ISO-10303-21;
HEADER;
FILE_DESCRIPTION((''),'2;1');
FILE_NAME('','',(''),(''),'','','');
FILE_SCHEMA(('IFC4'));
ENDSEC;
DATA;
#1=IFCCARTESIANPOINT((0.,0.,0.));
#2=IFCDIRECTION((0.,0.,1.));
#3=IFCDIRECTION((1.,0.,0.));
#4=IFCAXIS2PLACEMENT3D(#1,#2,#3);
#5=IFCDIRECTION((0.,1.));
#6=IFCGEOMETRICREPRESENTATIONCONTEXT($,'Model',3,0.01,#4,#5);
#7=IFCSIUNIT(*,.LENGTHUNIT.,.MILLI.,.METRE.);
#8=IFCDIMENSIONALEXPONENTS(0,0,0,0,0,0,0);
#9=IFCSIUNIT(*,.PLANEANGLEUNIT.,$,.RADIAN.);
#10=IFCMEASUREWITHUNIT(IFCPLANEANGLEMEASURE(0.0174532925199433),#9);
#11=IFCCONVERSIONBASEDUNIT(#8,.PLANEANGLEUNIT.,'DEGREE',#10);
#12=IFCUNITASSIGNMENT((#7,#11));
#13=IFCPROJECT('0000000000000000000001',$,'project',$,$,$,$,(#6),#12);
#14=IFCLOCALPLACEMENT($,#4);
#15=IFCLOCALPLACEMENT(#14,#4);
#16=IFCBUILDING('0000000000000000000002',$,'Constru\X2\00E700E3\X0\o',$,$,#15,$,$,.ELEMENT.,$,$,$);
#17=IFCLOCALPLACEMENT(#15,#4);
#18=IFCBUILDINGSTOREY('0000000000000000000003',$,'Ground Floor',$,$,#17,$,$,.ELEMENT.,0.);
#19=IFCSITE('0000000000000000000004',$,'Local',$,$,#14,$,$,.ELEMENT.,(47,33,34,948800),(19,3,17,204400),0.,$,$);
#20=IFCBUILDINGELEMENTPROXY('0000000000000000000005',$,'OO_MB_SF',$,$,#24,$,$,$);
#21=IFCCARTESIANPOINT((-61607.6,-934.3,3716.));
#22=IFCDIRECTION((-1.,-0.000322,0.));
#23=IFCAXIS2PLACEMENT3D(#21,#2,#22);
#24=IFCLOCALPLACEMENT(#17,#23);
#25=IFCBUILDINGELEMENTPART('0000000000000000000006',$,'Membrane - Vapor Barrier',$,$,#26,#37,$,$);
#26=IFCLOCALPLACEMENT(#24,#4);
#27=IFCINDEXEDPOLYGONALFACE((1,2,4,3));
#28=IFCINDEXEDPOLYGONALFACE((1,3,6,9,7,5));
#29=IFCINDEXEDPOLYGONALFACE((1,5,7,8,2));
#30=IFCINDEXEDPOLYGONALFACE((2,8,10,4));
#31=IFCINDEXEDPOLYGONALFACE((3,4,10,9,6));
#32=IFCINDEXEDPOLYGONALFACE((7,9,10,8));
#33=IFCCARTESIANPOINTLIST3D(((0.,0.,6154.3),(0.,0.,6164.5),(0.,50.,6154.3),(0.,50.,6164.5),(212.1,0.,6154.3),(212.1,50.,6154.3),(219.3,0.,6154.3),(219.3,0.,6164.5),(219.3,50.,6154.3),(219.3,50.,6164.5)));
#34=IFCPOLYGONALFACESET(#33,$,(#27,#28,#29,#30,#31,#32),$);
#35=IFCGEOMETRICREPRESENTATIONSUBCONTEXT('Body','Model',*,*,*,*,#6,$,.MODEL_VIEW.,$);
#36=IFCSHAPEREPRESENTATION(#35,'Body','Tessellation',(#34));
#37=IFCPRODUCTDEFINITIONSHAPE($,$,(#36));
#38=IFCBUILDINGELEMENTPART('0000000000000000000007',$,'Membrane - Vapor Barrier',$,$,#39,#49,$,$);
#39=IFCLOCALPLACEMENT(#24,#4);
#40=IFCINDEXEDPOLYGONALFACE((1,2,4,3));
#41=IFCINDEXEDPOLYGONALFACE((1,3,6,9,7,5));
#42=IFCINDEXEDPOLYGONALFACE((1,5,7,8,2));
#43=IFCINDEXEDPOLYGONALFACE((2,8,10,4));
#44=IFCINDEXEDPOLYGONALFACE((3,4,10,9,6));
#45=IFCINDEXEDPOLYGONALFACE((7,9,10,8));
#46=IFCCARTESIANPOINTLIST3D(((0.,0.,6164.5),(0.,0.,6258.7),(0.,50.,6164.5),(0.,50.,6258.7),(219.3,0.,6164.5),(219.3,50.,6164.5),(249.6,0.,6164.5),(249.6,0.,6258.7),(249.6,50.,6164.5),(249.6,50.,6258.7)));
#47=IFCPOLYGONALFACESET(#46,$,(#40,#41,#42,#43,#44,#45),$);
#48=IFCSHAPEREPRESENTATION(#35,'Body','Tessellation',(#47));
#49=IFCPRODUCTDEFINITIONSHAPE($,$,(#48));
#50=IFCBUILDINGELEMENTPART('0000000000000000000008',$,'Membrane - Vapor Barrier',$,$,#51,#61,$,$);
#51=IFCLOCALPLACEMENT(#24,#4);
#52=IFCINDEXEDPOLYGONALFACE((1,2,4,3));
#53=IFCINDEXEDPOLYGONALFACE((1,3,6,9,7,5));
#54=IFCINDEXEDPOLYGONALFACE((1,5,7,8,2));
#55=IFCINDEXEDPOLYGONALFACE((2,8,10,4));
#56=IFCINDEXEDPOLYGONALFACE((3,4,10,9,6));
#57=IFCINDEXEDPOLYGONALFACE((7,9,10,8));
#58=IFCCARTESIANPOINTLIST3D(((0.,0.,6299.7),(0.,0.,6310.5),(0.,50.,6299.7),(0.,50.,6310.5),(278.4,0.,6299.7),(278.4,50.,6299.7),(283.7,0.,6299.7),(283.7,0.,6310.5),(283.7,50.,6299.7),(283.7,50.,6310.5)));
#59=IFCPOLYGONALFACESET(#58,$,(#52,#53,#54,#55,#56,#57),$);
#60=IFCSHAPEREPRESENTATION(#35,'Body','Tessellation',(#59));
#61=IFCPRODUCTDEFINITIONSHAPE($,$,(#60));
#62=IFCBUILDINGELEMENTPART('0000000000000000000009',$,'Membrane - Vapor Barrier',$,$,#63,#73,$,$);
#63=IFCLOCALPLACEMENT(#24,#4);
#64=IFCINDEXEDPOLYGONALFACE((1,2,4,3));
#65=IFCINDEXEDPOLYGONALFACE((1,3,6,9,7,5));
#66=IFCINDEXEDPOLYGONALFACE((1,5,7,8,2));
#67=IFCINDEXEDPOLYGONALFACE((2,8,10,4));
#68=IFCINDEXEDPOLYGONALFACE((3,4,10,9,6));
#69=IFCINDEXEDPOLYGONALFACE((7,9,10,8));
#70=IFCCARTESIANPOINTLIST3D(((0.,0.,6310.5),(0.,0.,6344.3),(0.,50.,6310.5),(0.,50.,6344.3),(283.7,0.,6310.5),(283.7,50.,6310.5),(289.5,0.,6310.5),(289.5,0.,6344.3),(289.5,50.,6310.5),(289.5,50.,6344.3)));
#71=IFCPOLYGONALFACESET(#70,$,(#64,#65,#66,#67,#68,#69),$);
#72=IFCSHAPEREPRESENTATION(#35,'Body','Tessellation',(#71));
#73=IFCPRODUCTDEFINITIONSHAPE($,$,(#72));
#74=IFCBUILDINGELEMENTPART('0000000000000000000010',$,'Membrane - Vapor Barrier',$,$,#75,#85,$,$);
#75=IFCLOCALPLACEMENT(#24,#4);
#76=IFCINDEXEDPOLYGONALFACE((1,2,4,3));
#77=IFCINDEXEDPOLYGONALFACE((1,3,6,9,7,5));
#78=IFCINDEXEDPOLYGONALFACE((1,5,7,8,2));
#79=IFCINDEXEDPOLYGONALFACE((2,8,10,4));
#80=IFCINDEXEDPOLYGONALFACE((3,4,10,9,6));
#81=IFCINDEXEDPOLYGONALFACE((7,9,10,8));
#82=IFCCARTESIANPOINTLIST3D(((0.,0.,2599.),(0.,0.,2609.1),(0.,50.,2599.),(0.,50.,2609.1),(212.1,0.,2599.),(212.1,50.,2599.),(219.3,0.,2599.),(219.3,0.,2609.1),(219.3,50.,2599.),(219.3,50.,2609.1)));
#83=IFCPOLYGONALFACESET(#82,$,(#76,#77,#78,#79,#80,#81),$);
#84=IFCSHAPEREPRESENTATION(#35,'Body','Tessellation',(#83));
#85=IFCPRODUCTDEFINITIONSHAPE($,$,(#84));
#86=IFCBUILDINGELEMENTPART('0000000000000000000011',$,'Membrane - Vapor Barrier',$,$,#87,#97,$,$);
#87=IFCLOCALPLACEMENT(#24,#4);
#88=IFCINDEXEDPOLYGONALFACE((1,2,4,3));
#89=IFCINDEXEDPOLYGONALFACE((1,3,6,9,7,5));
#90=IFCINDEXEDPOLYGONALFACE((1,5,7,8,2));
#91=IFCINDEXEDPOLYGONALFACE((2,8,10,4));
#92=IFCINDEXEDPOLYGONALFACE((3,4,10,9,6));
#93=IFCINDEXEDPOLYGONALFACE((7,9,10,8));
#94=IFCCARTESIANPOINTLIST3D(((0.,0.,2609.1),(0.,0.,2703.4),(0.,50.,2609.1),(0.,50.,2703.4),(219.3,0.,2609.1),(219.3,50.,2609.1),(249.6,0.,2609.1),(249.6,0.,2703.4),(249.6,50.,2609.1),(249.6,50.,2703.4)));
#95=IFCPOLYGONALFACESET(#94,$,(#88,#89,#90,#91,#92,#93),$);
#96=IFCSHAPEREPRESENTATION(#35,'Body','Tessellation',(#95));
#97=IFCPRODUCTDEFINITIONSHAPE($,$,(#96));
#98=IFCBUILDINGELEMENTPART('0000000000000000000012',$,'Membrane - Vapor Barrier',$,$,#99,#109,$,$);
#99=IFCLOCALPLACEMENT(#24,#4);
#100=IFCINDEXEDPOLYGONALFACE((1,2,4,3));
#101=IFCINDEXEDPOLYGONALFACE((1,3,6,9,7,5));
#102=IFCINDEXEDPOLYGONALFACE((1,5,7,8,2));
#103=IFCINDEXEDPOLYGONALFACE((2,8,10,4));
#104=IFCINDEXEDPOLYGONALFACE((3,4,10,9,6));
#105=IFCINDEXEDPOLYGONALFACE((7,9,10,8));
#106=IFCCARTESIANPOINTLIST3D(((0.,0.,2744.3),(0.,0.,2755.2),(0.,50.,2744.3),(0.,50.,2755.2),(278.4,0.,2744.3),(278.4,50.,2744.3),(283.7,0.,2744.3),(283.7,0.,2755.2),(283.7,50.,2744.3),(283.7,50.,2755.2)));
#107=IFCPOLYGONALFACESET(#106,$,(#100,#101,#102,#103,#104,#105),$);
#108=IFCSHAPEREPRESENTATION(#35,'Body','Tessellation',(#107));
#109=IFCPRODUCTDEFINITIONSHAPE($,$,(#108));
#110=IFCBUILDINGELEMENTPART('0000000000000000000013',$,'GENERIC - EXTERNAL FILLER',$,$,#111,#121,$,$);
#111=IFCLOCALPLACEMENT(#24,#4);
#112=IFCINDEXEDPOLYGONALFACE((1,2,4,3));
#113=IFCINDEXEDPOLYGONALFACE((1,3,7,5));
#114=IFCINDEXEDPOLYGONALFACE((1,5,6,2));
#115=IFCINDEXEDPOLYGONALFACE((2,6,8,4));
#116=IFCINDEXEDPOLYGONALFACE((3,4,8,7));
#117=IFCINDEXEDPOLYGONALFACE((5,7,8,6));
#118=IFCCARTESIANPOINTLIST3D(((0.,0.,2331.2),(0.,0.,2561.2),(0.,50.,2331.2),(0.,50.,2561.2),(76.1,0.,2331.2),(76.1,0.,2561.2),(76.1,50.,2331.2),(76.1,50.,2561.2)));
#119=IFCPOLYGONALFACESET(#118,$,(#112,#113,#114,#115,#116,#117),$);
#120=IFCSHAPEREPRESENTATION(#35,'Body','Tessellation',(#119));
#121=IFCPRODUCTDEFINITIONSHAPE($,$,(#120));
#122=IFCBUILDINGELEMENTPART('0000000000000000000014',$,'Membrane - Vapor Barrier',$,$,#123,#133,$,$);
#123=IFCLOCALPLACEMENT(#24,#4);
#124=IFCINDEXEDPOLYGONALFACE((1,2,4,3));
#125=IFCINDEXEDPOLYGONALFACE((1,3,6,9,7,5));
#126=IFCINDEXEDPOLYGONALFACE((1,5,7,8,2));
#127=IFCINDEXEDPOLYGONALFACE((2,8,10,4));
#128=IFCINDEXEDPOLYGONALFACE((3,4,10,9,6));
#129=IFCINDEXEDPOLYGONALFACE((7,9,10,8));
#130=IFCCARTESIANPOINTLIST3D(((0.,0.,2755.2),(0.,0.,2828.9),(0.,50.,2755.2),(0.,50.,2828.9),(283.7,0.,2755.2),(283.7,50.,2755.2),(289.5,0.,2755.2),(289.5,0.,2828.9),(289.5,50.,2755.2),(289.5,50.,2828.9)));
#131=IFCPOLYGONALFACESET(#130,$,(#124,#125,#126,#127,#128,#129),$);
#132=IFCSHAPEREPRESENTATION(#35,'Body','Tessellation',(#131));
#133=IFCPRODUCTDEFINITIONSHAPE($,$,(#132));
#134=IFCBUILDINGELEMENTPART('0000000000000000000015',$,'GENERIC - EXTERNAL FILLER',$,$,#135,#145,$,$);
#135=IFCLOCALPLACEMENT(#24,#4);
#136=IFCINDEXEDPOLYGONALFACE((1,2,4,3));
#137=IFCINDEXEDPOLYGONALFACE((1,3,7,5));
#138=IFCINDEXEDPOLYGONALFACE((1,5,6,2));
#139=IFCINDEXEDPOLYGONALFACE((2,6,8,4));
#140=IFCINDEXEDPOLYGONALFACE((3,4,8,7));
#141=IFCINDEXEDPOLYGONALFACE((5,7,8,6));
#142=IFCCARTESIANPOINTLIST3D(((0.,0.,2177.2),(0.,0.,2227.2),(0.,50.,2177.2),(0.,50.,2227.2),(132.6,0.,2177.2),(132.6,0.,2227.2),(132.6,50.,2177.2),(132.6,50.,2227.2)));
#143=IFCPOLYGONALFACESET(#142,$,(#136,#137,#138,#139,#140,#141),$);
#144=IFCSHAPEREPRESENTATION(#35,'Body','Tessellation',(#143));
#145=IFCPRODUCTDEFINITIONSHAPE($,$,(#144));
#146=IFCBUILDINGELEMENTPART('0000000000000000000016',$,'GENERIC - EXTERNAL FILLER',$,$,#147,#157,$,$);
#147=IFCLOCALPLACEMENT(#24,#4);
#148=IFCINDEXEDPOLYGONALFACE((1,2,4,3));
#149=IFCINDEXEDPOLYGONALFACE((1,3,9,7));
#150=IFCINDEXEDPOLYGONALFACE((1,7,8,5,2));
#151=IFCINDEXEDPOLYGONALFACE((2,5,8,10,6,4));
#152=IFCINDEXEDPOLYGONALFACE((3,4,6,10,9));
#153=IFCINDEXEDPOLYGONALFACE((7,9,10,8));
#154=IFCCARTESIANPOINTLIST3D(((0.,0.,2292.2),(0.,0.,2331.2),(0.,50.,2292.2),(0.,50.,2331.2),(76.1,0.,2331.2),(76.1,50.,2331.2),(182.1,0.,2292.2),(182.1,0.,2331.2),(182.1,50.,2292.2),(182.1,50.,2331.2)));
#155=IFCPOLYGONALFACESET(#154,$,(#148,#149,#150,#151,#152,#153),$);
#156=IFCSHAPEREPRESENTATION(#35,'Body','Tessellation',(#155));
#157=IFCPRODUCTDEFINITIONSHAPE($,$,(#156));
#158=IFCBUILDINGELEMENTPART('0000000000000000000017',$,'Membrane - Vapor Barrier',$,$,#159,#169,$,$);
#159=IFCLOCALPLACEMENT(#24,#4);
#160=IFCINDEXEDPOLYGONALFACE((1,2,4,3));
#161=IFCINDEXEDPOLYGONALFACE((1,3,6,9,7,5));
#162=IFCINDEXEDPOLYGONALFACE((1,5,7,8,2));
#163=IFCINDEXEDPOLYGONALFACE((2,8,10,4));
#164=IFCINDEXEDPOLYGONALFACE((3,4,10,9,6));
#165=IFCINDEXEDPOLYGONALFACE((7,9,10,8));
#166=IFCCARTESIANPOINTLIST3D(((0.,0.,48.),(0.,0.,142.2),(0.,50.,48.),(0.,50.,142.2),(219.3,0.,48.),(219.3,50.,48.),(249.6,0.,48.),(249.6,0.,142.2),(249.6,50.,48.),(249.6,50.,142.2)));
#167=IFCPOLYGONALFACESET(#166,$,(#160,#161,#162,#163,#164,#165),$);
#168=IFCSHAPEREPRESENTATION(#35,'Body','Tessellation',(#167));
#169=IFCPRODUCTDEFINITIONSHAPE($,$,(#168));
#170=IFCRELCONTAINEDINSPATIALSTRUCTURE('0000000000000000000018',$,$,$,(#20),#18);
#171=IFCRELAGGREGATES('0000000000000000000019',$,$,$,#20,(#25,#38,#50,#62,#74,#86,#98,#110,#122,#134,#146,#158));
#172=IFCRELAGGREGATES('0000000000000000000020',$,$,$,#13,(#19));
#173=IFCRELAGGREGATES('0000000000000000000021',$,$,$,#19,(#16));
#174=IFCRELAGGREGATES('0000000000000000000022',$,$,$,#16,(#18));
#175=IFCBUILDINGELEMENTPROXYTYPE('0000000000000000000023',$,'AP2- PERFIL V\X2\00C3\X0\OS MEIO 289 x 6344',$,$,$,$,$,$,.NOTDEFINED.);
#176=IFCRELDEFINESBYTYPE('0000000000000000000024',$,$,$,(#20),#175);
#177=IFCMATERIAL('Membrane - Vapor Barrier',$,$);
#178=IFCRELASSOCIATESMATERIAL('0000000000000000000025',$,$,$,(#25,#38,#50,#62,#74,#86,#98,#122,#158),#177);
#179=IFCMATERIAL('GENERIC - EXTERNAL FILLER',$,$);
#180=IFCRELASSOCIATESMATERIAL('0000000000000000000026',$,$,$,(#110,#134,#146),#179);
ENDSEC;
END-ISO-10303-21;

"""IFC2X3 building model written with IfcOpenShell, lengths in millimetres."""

from ifc_helpers import new_model, entity, si_unit, converted_unit, direction, frame, origin_with_axes, place, context, subcontext, project, spatial, polyline, outline, extrude, material, type_object, element, aggregate, save


model = new_model("IFC2X3")

# Units and contexts
model_context = context("Model", 3, precision=0.01, world=origin_with_axes(), true_north=direction((0.0, 1.0)))
body_context = subcontext(model_context, "Body", "Model", "MODEL_VIEW")
ifc_project = project(units=[si_unit("LENGTHUNIT", "METRE", prefix="MILLI"), converted_unit("PLANEANGLEUNIT", "DEGREE", entity("IfcPlaneAngleMeasure", 0.0174532925199433), si_unit("PLANEANGLEUNIT", "RADIAN"), dimensions=[0, 0, 0, 0, 0, 0, 0])], contexts=[model_context])

# Site, building, storey
site_placement = place(None, origin_with_axes())
site = spatial("IfcSite", under=ifc_project, at=site_placement, Name="Local", CompositionType="ELEMENT", RefLatitude=(47, 33, 34, 948800), RefLongitude=(19, 3, 17, 204400), RefElevation=0.0)
building_placement = place(site_placement, origin_with_axes())
building = spatial("IfcBuilding", under=site, at=building_placement, Name="Construção", CompositionType="ELEMENT")
storey_placement = place(building_placement, origin_with_axes())
storey = spatial("IfcBuildingStorey", under=building, at=storey_placement, Name="Ground Floor", CompositionType="ELEMENT", Elevation=0.0)

# Building element proxy, building element parts
building_element_proxy_type = type_object("IfcBuildingElementProxyType", Name="AP2- PERFIL VÃOS MEIO 289 x 6344", PredefinedType="NOTDEFINED")
proxy_1_placement = place(storey_placement, frame((-61607.6, -934.3, 3716.0), z_axis=(0.0, 0.0, 1.0), x_axis=(-1.0, -0.000322, 0.0)))
proxy_1 = element("IfcBuildingElementProxy", 1, at=proxy_1_placement, inside=storey, type_object=building_element_proxy_type, Name="OO_MB_SF")
ifc_material_1 = material(Name="Membrane - Vapor Barrier")
building_element_part_1_placement = place(proxy_1_placement, origin_with_axes())
building_element_part_1 = element("IfcBuildingElementPart", 2, at=building_element_part_1_placement, material=ifc_material_1, Name="Membrane - Vapor Barrier", context=body_context, shape_type="SweptSolid", body=[
    extrude(outline(polyline([(0.0, 6154.3), (212.1, 6154.3), (219.3, 6154.3), (219.3, 6164.5), (0.0, 6164.5), (0.0, 6154.3)])), frame((0.0, 50.0, 0.0), z_axis=(0.0, -1.0, 0.0), x_axis=(1.0, 0.0, 0.0)), (0.0, 0.0, 1.0), 50.0),
])
building_element_part_2_placement = place(proxy_1_placement, origin_with_axes())
building_element_part_2 = element("IfcBuildingElementPart", 3, at=building_element_part_2_placement, material=ifc_material_1, Name="Membrane - Vapor Barrier", context=body_context, shape_type="SweptSolid", body=[
    extrude(outline(polyline([(249.6, 6258.7), (0.0, 6258.7), (0.0, 6164.5), (219.3, 6164.5), (249.6, 6164.5), (249.6, 6258.7)])), frame((0.0, 50.0, 0.0), z_axis=(0.0, -1.0, 0.0), x_axis=(1.0, 0.0, 0.0)), (0.0, 0.0, 1.0), 50.0),
])
building_element_part_3_placement = place(proxy_1_placement, origin_with_axes())
building_element_part_3 = element("IfcBuildingElementPart", 4, at=building_element_part_3_placement, material=ifc_material_1, Name="Membrane - Vapor Barrier", context=body_context, shape_type="SweptSolid", body=[
    extrude(outline(polyline([(0.0, 6299.7), (278.4, 6299.7), (283.7, 6299.7), (283.7, 6310.5), (0.0, 6310.5), (0.0, 6299.7)])), frame((0.0, 50.0, 0.0), z_axis=(0.0, -1.0, 0.0), x_axis=(1.0, 0.0, 0.0)), (0.0, 0.0, 1.0), 50.0),
])
building_element_part_4_placement = place(proxy_1_placement, origin_with_axes())
building_element_part_4 = element("IfcBuildingElementPart", 5, at=building_element_part_4_placement, material=ifc_material_1, Name="Membrane - Vapor Barrier", context=body_context, shape_type="SweptSolid", body=[
    extrude(outline(polyline([(0.0, 6310.5), (283.7, 6310.5), (289.5, 6310.5), (289.5, 6344.3), (0.0, 6344.3), (0.0, 6310.5)])), frame((0.0, 50.0, 0.0), z_axis=(0.0, -1.0, 0.0), x_axis=(1.0, 0.0, 0.0)), (0.0, 0.0, 1.0), 50.0),
])
building_element_part_5_placement = place(proxy_1_placement, origin_with_axes())
building_element_part_5 = element("IfcBuildingElementPart", 6, at=building_element_part_5_placement, material=ifc_material_1, Name="Membrane - Vapor Barrier", context=body_context, shape_type="SweptSolid", body=[
    extrude(outline(polyline([(0.0, 2599.0), (212.1, 2599.0), (219.3, 2599.0), (219.3, 2609.1), (0.0, 2609.1), (0.0, 2599.0)])), frame((0.0, 50.0, 0.0), z_axis=(0.0, -1.0, 0.0), x_axis=(1.0, 0.0, 0.0)), (0.0, 0.0, 1.0), 50.0),
])
building_element_part_6_placement = place(proxy_1_placement, origin_with_axes())
building_element_part_6 = element("IfcBuildingElementPart", 7, at=building_element_part_6_placement, material=ifc_material_1, Name="Membrane - Vapor Barrier", context=body_context, shape_type="SweptSolid", body=[
    extrude(outline(polyline([(249.6, 2703.4), (0.0, 2703.4), (0.0, 2609.1), (219.3, 2609.1), (249.6, 2609.1), (249.6, 2703.4)])), frame((0.0, 50.0, 0.0), z_axis=(0.0, -1.0, 0.0), x_axis=(1.0, 0.0, 0.0)), (0.0, 0.0, 1.0), 50.0),
])
building_element_part_7_placement = place(proxy_1_placement, origin_with_axes())
building_element_part_7 = element("IfcBuildingElementPart", 8, at=building_element_part_7_placement, material=ifc_material_1, Name="Membrane - Vapor Barrier", context=body_context, shape_type="SweptSolid", body=[
    extrude(outline(polyline([(0.0, 2744.3), (278.4, 2744.3), (283.7, 2744.3), (283.7, 2755.2), (0.0, 2755.2), (0.0, 2744.3)])), frame((0.0, 50.0, 0.0), z_axis=(0.0, -1.0, 0.0), x_axis=(1.0, 0.0, 0.0)), (0.0, 0.0, 1.0), 50.0),
])
ifc_material_2 = material(Name="GENERIC - EXTERNAL FILLER")
building_element_part_8_placement = place(proxy_1_placement, origin_with_axes())
building_element_part_8 = element("IfcBuildingElementPart", 9, at=building_element_part_8_placement, material=ifc_material_2, Name="GENERIC - EXTERNAL FILLER", context=body_context, shape_type="SweptSolid", body=[
    extrude(outline(polyline([(76.1, 2561.2), (0.0, 2561.2), (0.0, 2331.2), (76.1, 2331.2), (76.1, 2561.2)])), frame((0.0, 50.0, 0.0), z_axis=(0.0, -1.0, 0.0), x_axis=(1.0, 0.0, 0.0)), (0.0, 0.0, 1.0), 50.0),
])
building_element_part_9_placement = place(proxy_1_placement, origin_with_axes())
building_element_part_9 = element("IfcBuildingElementPart", 10, at=building_element_part_9_placement, material=ifc_material_1, Name="Membrane - Vapor Barrier", context=body_context, shape_type="SweptSolid", body=[
    extrude(outline(polyline([(0.0, 2755.2), (283.7, 2755.2), (289.5, 2755.2), (289.5, 2828.9), (0.0, 2828.9), (0.0, 2755.2)])), frame((0.0, 50.0, 0.0), z_axis=(0.0, -1.0, 0.0), x_axis=(1.0, 0.0, 0.0)), (0.0, 0.0, 1.0), 50.0),
])
building_element_part_10_placement = place(proxy_1_placement, origin_with_axes())
building_element_part_10 = element("IfcBuildingElementPart", 11, at=building_element_part_10_placement, material=ifc_material_2, Name="GENERIC - EXTERNAL FILLER", context=body_context, shape_type="SweptSolid", body=[
    extrude(outline(polyline([(0.0, 2227.2), (0.0, 2177.2), (132.6, 2177.2), (132.6, 2227.2), (0.0, 2227.2)])), frame((0.0, 50.0, 0.0), z_axis=(0.0, -1.0, 0.0), x_axis=(1.0, 0.0, 0.0)), (0.0, 0.0, 1.0), 50.0),
])
building_element_part_11_placement = place(proxy_1_placement, origin_with_axes())
building_element_part_11 = element("IfcBuildingElementPart", 12, at=building_element_part_11_placement, material=ifc_material_2, Name="GENERIC - EXTERNAL FILLER", context=body_context, shape_type="SweptSolid", body=[
    extrude(outline(polyline([(0.0, 2331.2), (0.0, 2292.2), (182.1, 2292.2), (182.1, 2331.2), (76.1, 2331.2), (0.0, 2331.2)])), frame((0.0, 50.0, 0.0), z_axis=(0.0, -1.0, 0.0), x_axis=(1.0, 0.0, 0.0)), (0.0, 0.0, 1.0), 50.0),
])
building_element_part_12_placement = place(proxy_1_placement, origin_with_axes())
building_element_part_12 = element("IfcBuildingElementPart", 13, at=building_element_part_12_placement, material=ifc_material_1, Name="Membrane - Vapor Barrier", context=body_context, shape_type="SweptSolid", body=[
    extrude(outline(polyline([(249.6, 142.2), (0.0, 142.2), (0.0, 48.0), (219.3, 48.0), (249.6, 48.0), (249.6, 142.2)])), frame((0.0, 50.0, 0.0), z_axis=(0.0, -1.0, 0.0), x_axis=(1.0, 0.0, 0.0)), (0.0, 0.0, 1.0), 50.0),
])
aggregate(proxy_1, [building_element_part_1, building_element_part_2, building_element_part_3, building_element_part_4, building_element_part_5, building_element_part_6, building_element_part_7, building_element_part_8, building_element_part_9, building_element_part_10, building_element_part_11, building_element_part_12])

save(model, "model.ifc")
